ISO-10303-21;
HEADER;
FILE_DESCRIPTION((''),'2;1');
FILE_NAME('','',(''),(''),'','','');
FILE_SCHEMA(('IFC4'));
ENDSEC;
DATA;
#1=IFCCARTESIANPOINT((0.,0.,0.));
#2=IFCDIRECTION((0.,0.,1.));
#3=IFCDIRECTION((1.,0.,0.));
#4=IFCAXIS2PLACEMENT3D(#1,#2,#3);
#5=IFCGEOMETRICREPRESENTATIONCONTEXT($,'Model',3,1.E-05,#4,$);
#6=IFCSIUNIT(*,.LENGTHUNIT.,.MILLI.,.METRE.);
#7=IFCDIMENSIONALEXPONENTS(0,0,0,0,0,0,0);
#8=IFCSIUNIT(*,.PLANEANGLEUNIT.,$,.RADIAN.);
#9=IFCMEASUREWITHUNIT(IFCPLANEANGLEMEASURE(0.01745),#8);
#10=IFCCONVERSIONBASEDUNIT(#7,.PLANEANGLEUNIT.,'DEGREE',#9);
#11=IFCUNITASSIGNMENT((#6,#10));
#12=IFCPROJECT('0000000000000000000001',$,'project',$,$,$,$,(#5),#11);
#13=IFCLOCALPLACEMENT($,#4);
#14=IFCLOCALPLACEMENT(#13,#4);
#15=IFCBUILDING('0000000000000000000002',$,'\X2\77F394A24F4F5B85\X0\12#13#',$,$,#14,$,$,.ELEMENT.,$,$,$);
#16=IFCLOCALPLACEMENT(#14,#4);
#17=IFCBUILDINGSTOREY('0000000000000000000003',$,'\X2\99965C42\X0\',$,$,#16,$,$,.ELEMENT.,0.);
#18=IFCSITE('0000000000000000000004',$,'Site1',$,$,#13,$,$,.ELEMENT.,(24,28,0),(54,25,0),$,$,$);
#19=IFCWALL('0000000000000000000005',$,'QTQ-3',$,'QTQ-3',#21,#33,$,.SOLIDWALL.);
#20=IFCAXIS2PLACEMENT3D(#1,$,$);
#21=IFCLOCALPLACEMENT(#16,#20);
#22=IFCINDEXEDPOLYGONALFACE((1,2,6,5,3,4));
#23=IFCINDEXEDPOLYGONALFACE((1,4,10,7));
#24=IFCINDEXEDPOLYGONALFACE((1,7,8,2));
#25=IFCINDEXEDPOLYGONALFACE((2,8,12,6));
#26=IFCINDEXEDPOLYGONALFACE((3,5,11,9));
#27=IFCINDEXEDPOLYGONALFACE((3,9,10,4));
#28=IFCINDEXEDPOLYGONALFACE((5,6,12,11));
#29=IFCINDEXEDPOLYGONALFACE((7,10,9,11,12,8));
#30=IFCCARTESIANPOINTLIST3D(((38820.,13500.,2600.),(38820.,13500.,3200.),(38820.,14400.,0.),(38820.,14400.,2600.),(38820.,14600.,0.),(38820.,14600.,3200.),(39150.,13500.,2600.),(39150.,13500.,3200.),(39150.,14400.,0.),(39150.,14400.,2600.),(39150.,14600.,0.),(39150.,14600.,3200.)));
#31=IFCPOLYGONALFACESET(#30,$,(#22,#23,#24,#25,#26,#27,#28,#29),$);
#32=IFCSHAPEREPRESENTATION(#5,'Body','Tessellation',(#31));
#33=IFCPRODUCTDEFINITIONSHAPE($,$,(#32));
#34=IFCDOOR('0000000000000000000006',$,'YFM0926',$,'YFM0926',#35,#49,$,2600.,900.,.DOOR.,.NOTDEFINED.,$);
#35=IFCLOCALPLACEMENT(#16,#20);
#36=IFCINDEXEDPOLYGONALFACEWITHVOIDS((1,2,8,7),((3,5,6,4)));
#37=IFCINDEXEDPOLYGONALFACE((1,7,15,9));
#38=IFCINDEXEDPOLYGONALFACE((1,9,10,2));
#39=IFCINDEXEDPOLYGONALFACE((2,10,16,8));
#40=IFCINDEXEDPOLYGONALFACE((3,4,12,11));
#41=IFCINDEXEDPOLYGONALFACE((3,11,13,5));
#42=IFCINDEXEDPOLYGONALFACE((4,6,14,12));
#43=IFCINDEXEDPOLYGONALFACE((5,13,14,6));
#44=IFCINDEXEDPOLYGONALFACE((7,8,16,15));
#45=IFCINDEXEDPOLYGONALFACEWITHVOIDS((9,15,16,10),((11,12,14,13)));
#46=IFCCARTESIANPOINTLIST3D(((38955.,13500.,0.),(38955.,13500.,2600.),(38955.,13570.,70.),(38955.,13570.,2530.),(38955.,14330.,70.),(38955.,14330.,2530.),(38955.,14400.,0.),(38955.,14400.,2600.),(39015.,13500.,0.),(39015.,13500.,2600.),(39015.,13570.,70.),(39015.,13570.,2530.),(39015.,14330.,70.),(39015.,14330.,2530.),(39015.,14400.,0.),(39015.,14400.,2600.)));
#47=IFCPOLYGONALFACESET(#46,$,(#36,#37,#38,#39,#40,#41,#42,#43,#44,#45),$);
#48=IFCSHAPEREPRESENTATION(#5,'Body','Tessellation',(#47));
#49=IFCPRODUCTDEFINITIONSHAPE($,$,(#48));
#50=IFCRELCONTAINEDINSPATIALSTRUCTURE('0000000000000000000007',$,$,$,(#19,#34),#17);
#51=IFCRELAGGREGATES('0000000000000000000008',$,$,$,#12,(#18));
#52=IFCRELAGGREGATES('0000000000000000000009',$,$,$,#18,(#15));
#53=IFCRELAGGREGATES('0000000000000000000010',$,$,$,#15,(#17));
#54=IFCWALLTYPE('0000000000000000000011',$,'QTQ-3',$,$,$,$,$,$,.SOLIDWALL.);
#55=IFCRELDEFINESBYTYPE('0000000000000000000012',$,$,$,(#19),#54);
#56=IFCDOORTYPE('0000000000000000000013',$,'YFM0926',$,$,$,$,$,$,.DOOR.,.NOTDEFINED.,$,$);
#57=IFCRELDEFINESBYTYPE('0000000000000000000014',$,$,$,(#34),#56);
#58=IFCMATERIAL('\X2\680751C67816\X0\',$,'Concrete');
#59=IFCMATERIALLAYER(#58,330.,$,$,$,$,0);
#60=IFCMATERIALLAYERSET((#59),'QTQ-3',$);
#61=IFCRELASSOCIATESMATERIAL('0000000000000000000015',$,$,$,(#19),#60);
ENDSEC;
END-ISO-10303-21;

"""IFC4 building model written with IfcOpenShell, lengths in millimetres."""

from ifc_helpers import new_model, entity, si_unit, converted_unit, frame, origin_with_axes, place, context, project, spatial, polyline, outline, extrude, material, layer, layer_set, type_object, element, fill, save


model = new_model("IFC4")

# Units and contexts
model_context = context("Model", 3, precision=1e-05, world=origin_with_axes())
ifc_project = project(units=[si_unit("LENGTHUNIT", "METRE", prefix="MILLI"), converted_unit("PLANEANGLEUNIT", "DEGREE", entity("IfcPlaneAngleMeasure", 0.01745), si_unit("PLANEANGLEUNIT", "RADIAN"), dimensions=[0, 0, 0, 0, 0, 0, 0])], contexts=[model_context])

# Site, building, storey
site_placement = place(None, origin_with_axes())
site = spatial("IfcSite", under=ifc_project, at=site_placement, Name="Site1", CompositionType="ELEMENT", RefLatitude=(24, 28, 0), RefLongitude=(54, 25, 0))
building_placement = place(site_placement, origin_with_axes())
building = spatial("IfcBuilding", under=site, at=building_placement, Name="石钢住宅12#13#", CompositionType="ELEMENT")
storey_placement = place(building_placement, origin_with_axes())
storey = spatial("IfcBuildingStorey", under=building, at=storey_placement, Name="首层", CompositionType="ELEMENT", Elevation=0.0)

# Shared definitions
ifc_material = material(Name="标准砖", Category="Concrete")
ifc_layer = layer(ifc_material, 330.0, Priority=0)
ifc_layer_set = layer_set([ifc_layer], Name="QTQ-3")
wall_type = type_object("IfcWallType", Name="QTQ-3", PredefinedType="SOLIDWALL")

# Shared definitions
door_type = type_object("IfcDoorType", Name="YFM0926", OperationType="NOTDEFINED", PredefinedType="DOOR")

# Wall, opening, door
wall_1_placement = place(storey_placement, origin_with_axes())
wall_1 = element("IfcWall", 1, at=wall_1_placement, inside=storey, type_object=wall_type, material=ifc_layer_set, Name="QTQ-3", ObjectType="QTQ-3", PredefinedType="SOLIDWALL", context=model_context, shape_type="SweptSolid", body=[
    extrude(outline(polyline([(0.0, 0.0), (3200.0, 0.0), (3200.0, 1100.0), (0.0, 1100.0), (0.0, 0.0)])), frame((39150.0, 14600.0, 3200.0), z_axis=(-1.0, 0.0, 0.0), x_axis=(0.0, 0.0, -1.0)), (0.0, 0.0, 1.0), 330.0),
])
opening_1_placement = place(storey_placement, origin_with_axes())
opening_1 = element("IfcOpeningElement", 2, at=opening_1_placement, cuts=wall_1, PredefinedType="OPENING", context=model_context, shape_type="SweptSolid", body=[
    extrude(outline(polyline([(0.0, 0.0), (2600.0, 0.0), (2600.0, 900.0), (0.0, 900.0), (0.0, 0.0)])), frame((40150.0, 13500.0, 0.0), z_axis=(-1.0, 0.0, 0.0), x_axis=(0.0, 0.0, 1.0)), (0.0, 0.0, 1.0), 2330.0),
])
door_1_placement = place(storey_placement, origin_with_axes())
door_1 = element("IfcDoor", 3, at=door_1_placement, inside=storey, type_object=door_type, Name="YFM0926", ObjectType="YFM0926", OperationType="NOTDEFINED", OverallHeight=2600.0, OverallWidth=900.0, PredefinedType="DOOR", context=model_context, shape_type="SweptSolid", body=[
    extrude(outline(polyline([(450.0, -1300.0), (450.0, 1300.0), (-450.0, 1300.0), (-450.0, -1300.0), (450.0, -1300.0)]), holes=[polyline([(380.0, -1230.0), (-380.0, -1230.0), (-380.0, 1230.0), (380.0, 1230.0), (380.0, -1230.0)])]), frame((39015.0, 13950.0, 1300.0), z_axis=(-1.0, 0.0, 0.0), x_axis=(0.0, -1.0, 0.0)), (0.0, 0.0, 1.0), 60.0),
])
fill(opening_1, door_1)

save(model, "model.ifc")
